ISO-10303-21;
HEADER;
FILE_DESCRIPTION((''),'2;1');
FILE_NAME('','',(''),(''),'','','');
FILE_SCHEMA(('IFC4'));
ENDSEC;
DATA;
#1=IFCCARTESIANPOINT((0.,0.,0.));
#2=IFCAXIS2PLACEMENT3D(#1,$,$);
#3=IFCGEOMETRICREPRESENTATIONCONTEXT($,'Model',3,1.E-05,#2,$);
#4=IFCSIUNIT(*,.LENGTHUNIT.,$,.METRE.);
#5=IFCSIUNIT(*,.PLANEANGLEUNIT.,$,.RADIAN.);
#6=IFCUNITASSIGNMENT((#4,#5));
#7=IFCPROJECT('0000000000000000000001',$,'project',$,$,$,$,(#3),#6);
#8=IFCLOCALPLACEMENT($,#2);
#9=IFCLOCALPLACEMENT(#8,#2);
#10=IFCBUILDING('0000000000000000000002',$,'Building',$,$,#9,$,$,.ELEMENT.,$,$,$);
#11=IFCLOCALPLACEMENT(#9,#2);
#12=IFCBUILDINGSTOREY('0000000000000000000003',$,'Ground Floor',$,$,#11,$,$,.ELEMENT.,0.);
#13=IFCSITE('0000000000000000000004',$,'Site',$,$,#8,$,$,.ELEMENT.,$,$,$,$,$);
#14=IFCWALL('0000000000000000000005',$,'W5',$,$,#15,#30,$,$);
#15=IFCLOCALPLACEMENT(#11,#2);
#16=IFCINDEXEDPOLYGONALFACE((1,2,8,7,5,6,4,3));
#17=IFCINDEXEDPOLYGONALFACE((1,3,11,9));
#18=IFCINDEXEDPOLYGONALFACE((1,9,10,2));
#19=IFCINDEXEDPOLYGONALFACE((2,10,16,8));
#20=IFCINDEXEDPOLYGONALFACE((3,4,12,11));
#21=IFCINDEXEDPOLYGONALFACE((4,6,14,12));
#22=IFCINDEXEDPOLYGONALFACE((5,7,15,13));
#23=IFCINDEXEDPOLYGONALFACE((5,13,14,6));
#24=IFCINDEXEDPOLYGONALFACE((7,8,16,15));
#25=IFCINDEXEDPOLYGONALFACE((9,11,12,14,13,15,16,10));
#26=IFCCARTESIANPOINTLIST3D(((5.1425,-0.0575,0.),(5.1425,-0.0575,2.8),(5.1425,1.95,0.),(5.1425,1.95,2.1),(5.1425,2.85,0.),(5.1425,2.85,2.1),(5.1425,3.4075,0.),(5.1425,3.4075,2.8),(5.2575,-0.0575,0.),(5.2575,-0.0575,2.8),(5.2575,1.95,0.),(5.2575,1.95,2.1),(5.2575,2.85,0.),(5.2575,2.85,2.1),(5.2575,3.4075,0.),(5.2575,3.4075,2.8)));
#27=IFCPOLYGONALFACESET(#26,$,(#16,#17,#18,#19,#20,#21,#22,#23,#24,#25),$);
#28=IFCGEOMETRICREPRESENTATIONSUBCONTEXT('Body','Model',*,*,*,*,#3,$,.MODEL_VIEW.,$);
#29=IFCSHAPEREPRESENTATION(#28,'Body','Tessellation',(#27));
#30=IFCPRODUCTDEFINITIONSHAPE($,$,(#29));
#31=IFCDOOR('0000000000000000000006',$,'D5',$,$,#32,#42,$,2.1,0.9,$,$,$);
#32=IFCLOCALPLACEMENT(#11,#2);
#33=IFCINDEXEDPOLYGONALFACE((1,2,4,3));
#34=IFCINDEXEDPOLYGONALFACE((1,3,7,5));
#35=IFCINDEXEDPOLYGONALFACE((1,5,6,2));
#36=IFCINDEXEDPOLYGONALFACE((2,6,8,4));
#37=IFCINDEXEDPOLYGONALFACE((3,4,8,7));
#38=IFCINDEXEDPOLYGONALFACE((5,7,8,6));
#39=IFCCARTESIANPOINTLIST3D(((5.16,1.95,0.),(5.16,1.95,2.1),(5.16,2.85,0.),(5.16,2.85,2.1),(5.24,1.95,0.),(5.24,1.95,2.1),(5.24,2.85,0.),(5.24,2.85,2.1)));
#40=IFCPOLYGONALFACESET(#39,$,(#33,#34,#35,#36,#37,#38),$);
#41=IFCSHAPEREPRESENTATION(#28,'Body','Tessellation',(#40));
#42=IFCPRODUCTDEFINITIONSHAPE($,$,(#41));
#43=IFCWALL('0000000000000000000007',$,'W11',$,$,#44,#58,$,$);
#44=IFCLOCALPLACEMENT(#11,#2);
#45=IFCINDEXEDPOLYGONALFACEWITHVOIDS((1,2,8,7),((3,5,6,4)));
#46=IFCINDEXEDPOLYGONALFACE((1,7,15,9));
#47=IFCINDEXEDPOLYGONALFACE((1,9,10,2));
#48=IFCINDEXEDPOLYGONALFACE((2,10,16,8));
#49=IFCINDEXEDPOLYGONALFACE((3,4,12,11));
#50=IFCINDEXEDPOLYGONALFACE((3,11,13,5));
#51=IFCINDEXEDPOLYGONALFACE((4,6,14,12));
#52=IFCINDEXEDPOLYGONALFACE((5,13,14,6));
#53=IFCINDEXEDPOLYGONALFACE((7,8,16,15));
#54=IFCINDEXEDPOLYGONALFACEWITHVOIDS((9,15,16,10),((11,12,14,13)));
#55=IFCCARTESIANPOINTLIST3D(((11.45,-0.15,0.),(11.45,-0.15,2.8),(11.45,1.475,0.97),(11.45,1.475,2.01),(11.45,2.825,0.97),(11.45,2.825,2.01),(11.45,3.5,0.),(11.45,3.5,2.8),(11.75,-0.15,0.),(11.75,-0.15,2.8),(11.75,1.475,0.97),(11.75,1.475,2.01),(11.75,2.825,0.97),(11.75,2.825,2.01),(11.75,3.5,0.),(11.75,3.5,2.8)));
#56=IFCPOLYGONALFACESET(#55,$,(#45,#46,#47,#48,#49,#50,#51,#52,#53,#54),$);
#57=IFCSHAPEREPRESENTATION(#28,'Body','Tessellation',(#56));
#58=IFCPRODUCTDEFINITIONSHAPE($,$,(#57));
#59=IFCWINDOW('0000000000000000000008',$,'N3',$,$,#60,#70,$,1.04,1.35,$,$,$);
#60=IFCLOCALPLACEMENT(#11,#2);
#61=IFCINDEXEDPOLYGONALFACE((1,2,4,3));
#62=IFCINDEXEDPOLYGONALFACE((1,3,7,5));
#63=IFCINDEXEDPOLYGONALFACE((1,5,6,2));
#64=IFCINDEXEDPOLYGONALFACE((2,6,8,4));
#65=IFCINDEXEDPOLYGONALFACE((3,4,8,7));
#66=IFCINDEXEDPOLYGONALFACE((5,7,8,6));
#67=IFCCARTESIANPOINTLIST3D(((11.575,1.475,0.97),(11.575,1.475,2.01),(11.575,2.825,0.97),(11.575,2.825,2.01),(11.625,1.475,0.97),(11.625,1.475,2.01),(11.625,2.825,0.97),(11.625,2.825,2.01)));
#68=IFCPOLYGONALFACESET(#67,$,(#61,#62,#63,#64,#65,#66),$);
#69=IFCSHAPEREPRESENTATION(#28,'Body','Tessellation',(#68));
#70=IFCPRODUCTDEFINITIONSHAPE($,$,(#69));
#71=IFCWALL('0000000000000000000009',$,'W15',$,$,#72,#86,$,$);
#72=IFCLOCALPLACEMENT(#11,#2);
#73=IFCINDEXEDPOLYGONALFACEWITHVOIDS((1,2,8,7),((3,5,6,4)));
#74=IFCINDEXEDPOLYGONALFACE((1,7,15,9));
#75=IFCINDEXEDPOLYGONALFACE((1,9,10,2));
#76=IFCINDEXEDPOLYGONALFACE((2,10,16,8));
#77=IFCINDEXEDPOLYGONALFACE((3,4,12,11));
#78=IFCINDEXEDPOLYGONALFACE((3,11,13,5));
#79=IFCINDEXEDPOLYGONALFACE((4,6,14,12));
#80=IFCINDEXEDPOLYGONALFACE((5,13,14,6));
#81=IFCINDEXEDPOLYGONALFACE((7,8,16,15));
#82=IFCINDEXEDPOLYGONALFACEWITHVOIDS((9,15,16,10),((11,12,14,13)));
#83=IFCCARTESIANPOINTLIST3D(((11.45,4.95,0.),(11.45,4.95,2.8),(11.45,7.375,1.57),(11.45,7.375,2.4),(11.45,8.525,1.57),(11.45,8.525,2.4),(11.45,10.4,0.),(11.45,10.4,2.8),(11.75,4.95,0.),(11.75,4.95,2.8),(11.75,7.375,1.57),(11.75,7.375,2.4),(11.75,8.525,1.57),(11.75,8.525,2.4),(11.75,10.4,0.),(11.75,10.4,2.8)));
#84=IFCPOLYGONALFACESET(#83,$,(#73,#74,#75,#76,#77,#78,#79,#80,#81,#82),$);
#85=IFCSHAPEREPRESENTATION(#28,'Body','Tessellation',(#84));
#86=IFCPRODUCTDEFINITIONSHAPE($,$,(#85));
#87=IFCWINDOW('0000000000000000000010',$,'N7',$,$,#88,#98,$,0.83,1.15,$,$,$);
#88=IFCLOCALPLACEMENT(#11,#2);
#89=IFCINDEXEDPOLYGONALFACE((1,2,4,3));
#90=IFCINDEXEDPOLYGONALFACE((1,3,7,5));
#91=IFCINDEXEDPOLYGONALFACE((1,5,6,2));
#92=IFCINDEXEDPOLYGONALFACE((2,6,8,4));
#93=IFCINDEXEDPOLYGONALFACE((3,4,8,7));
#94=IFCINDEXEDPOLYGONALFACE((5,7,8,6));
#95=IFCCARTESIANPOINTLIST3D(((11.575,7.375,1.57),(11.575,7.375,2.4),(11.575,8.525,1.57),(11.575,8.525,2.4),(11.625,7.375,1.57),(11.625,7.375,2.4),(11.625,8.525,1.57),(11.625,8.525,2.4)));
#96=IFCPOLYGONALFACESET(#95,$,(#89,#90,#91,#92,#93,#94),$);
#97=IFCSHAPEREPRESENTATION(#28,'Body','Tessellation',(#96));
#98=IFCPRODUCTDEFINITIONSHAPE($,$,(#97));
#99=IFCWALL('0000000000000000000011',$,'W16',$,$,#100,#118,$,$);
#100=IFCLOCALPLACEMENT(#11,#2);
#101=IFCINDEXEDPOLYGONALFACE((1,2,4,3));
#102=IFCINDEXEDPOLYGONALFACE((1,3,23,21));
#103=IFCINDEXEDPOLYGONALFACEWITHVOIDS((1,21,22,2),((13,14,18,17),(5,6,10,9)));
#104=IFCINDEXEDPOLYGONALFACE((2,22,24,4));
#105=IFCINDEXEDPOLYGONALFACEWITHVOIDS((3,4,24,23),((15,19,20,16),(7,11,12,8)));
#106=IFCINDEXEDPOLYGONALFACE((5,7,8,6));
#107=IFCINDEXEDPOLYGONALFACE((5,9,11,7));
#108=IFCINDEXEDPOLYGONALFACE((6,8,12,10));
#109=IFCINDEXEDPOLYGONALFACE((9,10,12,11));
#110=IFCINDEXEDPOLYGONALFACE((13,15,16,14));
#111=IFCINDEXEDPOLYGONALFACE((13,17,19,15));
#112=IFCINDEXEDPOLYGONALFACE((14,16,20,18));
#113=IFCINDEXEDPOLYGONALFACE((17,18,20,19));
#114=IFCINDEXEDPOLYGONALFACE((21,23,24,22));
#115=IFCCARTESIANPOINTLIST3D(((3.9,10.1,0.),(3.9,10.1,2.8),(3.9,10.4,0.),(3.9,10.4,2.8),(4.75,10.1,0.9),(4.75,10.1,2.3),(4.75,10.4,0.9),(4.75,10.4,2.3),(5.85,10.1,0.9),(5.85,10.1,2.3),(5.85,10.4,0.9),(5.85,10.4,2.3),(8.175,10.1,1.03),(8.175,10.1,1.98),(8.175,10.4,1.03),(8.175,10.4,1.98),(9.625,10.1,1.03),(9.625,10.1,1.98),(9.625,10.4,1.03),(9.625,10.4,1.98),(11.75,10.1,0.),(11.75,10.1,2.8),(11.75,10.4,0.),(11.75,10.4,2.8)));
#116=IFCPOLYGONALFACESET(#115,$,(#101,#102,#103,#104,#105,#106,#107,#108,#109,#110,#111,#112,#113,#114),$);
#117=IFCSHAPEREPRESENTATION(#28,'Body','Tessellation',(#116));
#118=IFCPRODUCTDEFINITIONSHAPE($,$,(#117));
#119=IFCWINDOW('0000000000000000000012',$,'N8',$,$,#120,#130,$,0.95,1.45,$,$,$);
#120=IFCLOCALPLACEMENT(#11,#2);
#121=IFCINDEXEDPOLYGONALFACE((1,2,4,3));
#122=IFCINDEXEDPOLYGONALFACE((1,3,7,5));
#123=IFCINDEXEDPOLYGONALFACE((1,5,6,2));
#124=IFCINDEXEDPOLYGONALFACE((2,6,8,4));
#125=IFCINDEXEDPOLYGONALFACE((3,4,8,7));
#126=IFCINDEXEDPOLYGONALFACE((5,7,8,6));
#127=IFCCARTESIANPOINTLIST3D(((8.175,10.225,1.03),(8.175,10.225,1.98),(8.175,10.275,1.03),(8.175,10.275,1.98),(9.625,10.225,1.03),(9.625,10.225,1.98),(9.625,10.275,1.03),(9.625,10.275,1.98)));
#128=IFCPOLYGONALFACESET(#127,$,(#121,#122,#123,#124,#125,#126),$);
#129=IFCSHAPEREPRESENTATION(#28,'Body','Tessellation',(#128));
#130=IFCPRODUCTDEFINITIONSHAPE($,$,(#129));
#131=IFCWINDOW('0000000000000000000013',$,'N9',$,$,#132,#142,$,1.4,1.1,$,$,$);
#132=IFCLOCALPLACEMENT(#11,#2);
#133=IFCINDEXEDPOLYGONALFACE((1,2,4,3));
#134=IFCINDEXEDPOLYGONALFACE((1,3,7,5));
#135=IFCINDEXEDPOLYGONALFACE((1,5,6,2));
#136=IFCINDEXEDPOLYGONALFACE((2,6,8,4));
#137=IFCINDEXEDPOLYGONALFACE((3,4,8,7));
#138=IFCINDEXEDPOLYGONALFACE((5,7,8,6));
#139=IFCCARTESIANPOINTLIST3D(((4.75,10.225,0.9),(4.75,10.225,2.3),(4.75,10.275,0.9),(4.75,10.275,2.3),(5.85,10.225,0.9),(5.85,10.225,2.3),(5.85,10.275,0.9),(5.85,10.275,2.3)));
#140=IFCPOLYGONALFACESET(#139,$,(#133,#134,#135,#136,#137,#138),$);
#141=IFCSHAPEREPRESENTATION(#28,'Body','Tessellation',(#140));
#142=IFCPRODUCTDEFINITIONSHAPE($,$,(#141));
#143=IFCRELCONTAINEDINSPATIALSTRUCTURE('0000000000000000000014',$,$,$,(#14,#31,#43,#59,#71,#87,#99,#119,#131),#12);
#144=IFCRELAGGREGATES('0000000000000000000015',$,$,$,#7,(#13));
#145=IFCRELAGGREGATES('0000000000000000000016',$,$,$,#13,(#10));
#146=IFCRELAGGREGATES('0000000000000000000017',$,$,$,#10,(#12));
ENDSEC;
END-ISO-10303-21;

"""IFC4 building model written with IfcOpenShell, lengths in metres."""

from ifc_helpers import new_model, si_unit, frame, frame_2d, origin, origin_2d, place, context, subcontext, project, spatial, rectangle, extrude, element, fill, save


model = new_model("IFC4")

# Units and contexts
model_context = context("Model", 3, precision=1e-05, world=origin())
body_context = subcontext(model_context, "Body", "Model", "MODEL_VIEW")
ifc_project = project(units=[si_unit("LENGTHUNIT", "METRE"), si_unit("PLANEANGLEUNIT", "RADIAN")], contexts=[model_context])

# Site, building, storey
site_placement = place(None, origin())
site = spatial("IfcSite", under=ifc_project, at=site_placement, Name="Site", CompositionType="ELEMENT")
building_placement = place(site_placement, origin())
building = spatial("IfcBuilding", under=site, at=building_placement, Name="Building", CompositionType="ELEMENT")
storey_placement = place(building_placement, origin())
storey = spatial("IfcBuildingStorey", under=building, at=storey_placement, Name="Ground Floor", CompositionType="ELEMENT", Elevation=0.0)

# Wall, opening, door
wall_1_placement = place(storey_placement, frame((5.2, 0.0, 0.0), x_axis=(0.0, 1.0, 0.0)))
wall_1 = element("IfcWall", 1, at=wall_1_placement, inside=storey, Name="W5", context=body_context, shape_type="SweptSolid", body=[
    extrude(rectangle(XDim=3.465, YDim=0.115, at=frame_2d((1.675, 0.0))), origin(), (0.0, 0.0, 1.0), 2.8),
])
opening_1_placement = place(wall_1_placement, frame((2.4, 0.0, 0.0)))
opening_1 = element("IfcOpeningElement", 2, at=opening_1_placement, cuts=wall_1, context=body_context, shape_type="SweptSolid", body=[
    extrude(rectangle(XDim=0.9, YDim=0.215, at=origin_2d()), origin(), (0.0, 0.0, 1.0), 2.1),
])
door_1_placement = place(opening_1_placement, origin())
door_1 = element("IfcDoor", 3, at=door_1_placement, inside=storey, Name="D5", OverallHeight=2.1, OverallWidth=0.9, context=body_context, shape_type="SweptSolid", body=[
    extrude(rectangle(XDim=0.9, YDim=0.08, at=origin_2d()), origin(), (0.0, 0.0, 1.0), 2.1),
])
fill(opening_1, door_1)

# Walls, openings, windows
wall_2_placement = place(storey_placement, frame((11.6, 0.0, 0.0), x_axis=(0.0, 1.0, 0.0)))
wall_2 = element("IfcWall", 4, at=wall_2_placement, inside=storey, Name="W11", context=body_context, shape_type="SweptSolid", body=[
    extrude(rectangle(XDim=3.65, YDim=0.3, at=frame_2d((1.675, 0.0))), origin(), (0.0, 0.0, 1.0), 2.8),
])
opening_2_placement = place(wall_2_placement, frame((2.15, 0.0, 0.97)))
opening_2 = element("IfcOpeningElement", 5, at=opening_2_placement, cuts=wall_2, context=body_context, shape_type="SweptSolid", body=[
    extrude(rectangle(XDim=1.35, YDim=0.4, at=origin_2d()), origin(), (0.0, 0.0, 1.0), 1.04),
])
window_1_placement = place(opening_2_placement, origin())
window_1 = element("IfcWindow", 6, at=window_1_placement, inside=storey, Name="N3", OverallHeight=1.04, OverallWidth=1.35, context=body_context, shape_type="SweptSolid", body=[
    extrude(rectangle(XDim=1.35, YDim=0.05, at=origin_2d()), origin(), (0.0, 0.0, 1.0), 1.04),
])
fill(opening_2, window_1)
wall_3_placement = place(storey_placement, frame((11.6, 5.1, 0.0), x_axis=(0.0, 1.0, 0.0)))
wall_3 = element("IfcWall", 7, at=wall_3_placement, inside=storey, Name="W15", context=body_context, shape_type="SweptSolid", body=[
    extrude(rectangle(XDim=5.45, YDim=0.3, at=frame_2d((2.575, 0.0))), origin(), (0.0, 0.0, 1.0), 2.8),
])
opening_3_placement = place(wall_3_placement, frame((2.85, 0.0, 1.57)))
opening_3 = element("IfcOpeningElement", 8, at=opening_3_placement, cuts=wall_3, context=body_context, shape_type="SweptSolid", body=[
    extrude(rectangle(XDim=1.15, YDim=0.4, at=origin_2d()), origin(), (0.0, 0.0, 1.0), 0.83),
])
window_2_placement = place(opening_3_placement, origin())
window_2 = element("IfcWindow", 9, at=window_2_placement, inside=storey, Name="N7", OverallHeight=0.83, OverallWidth=1.15, context=body_context, shape_type="SweptSolid", body=[
    extrude(rectangle(XDim=1.15, YDim=0.05, at=origin_2d()), origin(), (0.0, 0.0, 1.0), 0.83),
])
fill(opening_3, window_2)

# Wall, openings, windows
wall_4_placement = place(storey_placement, frame((4.05, 10.25, 0.0), x_axis=(1.0, 0.0, 0.0)))
wall_4 = element("IfcWall", 10, at=wall_4_placement, inside=storey, Name="W16", context=body_context, shape_type="SweptSolid", body=[
    extrude(rectangle(XDim=7.85, YDim=0.3, at=frame_2d((3.775, 0.0))), origin(), (0.0, 0.0, 1.0), 2.8),
])
opening_4_placement = place(wall_4_placement, frame((4.85, 0.0, 1.03)))
opening_4 = element("IfcOpeningElement", 11, at=opening_4_placement, cuts=wall_4, context=body_context, shape_type="SweptSolid", body=[
    extrude(rectangle(XDim=1.45, YDim=0.4, at=origin_2d()), origin(), (0.0, 0.0, 1.0), 0.95),
])
opening_5_placement = place(wall_4_placement, frame((1.25, 0.0, 0.9)))
opening_5 = element("IfcOpeningElement", 12, at=opening_5_placement, cuts=wall_4, context=body_context, shape_type="SweptSolid", body=[
    extrude(rectangle(XDim=1.1, YDim=0.4, at=origin_2d()), origin(), (0.0, 0.0, 1.0), 1.4),
])
window_3_placement = place(opening_4_placement, origin())
window_3 = element("IfcWindow", 13, at=window_3_placement, inside=storey, Name="N8", OverallHeight=0.95, OverallWidth=1.45, context=body_context, shape_type="SweptSolid", body=[
    extrude(rectangle(XDim=1.45, YDim=0.05, at=origin_2d()), origin(), (0.0, 0.0, 1.0), 0.95),
])
fill(opening_4, window_3)
window_4_placement = place(opening_5_placement, origin())
window_4 = element("IfcWindow", 14, at=window_4_placement, inside=storey, Name="N9", OverallHeight=1.4, OverallWidth=1.1, context=body_context, shape_type="SweptSolid", body=[
    extrude(rectangle(XDim=1.1, YDim=0.05, at=origin_2d()), origin(), (0.0, 0.0, 1.0), 1.4),
])
fill(opening_5, window_4)

save(model, "model.ifc")
